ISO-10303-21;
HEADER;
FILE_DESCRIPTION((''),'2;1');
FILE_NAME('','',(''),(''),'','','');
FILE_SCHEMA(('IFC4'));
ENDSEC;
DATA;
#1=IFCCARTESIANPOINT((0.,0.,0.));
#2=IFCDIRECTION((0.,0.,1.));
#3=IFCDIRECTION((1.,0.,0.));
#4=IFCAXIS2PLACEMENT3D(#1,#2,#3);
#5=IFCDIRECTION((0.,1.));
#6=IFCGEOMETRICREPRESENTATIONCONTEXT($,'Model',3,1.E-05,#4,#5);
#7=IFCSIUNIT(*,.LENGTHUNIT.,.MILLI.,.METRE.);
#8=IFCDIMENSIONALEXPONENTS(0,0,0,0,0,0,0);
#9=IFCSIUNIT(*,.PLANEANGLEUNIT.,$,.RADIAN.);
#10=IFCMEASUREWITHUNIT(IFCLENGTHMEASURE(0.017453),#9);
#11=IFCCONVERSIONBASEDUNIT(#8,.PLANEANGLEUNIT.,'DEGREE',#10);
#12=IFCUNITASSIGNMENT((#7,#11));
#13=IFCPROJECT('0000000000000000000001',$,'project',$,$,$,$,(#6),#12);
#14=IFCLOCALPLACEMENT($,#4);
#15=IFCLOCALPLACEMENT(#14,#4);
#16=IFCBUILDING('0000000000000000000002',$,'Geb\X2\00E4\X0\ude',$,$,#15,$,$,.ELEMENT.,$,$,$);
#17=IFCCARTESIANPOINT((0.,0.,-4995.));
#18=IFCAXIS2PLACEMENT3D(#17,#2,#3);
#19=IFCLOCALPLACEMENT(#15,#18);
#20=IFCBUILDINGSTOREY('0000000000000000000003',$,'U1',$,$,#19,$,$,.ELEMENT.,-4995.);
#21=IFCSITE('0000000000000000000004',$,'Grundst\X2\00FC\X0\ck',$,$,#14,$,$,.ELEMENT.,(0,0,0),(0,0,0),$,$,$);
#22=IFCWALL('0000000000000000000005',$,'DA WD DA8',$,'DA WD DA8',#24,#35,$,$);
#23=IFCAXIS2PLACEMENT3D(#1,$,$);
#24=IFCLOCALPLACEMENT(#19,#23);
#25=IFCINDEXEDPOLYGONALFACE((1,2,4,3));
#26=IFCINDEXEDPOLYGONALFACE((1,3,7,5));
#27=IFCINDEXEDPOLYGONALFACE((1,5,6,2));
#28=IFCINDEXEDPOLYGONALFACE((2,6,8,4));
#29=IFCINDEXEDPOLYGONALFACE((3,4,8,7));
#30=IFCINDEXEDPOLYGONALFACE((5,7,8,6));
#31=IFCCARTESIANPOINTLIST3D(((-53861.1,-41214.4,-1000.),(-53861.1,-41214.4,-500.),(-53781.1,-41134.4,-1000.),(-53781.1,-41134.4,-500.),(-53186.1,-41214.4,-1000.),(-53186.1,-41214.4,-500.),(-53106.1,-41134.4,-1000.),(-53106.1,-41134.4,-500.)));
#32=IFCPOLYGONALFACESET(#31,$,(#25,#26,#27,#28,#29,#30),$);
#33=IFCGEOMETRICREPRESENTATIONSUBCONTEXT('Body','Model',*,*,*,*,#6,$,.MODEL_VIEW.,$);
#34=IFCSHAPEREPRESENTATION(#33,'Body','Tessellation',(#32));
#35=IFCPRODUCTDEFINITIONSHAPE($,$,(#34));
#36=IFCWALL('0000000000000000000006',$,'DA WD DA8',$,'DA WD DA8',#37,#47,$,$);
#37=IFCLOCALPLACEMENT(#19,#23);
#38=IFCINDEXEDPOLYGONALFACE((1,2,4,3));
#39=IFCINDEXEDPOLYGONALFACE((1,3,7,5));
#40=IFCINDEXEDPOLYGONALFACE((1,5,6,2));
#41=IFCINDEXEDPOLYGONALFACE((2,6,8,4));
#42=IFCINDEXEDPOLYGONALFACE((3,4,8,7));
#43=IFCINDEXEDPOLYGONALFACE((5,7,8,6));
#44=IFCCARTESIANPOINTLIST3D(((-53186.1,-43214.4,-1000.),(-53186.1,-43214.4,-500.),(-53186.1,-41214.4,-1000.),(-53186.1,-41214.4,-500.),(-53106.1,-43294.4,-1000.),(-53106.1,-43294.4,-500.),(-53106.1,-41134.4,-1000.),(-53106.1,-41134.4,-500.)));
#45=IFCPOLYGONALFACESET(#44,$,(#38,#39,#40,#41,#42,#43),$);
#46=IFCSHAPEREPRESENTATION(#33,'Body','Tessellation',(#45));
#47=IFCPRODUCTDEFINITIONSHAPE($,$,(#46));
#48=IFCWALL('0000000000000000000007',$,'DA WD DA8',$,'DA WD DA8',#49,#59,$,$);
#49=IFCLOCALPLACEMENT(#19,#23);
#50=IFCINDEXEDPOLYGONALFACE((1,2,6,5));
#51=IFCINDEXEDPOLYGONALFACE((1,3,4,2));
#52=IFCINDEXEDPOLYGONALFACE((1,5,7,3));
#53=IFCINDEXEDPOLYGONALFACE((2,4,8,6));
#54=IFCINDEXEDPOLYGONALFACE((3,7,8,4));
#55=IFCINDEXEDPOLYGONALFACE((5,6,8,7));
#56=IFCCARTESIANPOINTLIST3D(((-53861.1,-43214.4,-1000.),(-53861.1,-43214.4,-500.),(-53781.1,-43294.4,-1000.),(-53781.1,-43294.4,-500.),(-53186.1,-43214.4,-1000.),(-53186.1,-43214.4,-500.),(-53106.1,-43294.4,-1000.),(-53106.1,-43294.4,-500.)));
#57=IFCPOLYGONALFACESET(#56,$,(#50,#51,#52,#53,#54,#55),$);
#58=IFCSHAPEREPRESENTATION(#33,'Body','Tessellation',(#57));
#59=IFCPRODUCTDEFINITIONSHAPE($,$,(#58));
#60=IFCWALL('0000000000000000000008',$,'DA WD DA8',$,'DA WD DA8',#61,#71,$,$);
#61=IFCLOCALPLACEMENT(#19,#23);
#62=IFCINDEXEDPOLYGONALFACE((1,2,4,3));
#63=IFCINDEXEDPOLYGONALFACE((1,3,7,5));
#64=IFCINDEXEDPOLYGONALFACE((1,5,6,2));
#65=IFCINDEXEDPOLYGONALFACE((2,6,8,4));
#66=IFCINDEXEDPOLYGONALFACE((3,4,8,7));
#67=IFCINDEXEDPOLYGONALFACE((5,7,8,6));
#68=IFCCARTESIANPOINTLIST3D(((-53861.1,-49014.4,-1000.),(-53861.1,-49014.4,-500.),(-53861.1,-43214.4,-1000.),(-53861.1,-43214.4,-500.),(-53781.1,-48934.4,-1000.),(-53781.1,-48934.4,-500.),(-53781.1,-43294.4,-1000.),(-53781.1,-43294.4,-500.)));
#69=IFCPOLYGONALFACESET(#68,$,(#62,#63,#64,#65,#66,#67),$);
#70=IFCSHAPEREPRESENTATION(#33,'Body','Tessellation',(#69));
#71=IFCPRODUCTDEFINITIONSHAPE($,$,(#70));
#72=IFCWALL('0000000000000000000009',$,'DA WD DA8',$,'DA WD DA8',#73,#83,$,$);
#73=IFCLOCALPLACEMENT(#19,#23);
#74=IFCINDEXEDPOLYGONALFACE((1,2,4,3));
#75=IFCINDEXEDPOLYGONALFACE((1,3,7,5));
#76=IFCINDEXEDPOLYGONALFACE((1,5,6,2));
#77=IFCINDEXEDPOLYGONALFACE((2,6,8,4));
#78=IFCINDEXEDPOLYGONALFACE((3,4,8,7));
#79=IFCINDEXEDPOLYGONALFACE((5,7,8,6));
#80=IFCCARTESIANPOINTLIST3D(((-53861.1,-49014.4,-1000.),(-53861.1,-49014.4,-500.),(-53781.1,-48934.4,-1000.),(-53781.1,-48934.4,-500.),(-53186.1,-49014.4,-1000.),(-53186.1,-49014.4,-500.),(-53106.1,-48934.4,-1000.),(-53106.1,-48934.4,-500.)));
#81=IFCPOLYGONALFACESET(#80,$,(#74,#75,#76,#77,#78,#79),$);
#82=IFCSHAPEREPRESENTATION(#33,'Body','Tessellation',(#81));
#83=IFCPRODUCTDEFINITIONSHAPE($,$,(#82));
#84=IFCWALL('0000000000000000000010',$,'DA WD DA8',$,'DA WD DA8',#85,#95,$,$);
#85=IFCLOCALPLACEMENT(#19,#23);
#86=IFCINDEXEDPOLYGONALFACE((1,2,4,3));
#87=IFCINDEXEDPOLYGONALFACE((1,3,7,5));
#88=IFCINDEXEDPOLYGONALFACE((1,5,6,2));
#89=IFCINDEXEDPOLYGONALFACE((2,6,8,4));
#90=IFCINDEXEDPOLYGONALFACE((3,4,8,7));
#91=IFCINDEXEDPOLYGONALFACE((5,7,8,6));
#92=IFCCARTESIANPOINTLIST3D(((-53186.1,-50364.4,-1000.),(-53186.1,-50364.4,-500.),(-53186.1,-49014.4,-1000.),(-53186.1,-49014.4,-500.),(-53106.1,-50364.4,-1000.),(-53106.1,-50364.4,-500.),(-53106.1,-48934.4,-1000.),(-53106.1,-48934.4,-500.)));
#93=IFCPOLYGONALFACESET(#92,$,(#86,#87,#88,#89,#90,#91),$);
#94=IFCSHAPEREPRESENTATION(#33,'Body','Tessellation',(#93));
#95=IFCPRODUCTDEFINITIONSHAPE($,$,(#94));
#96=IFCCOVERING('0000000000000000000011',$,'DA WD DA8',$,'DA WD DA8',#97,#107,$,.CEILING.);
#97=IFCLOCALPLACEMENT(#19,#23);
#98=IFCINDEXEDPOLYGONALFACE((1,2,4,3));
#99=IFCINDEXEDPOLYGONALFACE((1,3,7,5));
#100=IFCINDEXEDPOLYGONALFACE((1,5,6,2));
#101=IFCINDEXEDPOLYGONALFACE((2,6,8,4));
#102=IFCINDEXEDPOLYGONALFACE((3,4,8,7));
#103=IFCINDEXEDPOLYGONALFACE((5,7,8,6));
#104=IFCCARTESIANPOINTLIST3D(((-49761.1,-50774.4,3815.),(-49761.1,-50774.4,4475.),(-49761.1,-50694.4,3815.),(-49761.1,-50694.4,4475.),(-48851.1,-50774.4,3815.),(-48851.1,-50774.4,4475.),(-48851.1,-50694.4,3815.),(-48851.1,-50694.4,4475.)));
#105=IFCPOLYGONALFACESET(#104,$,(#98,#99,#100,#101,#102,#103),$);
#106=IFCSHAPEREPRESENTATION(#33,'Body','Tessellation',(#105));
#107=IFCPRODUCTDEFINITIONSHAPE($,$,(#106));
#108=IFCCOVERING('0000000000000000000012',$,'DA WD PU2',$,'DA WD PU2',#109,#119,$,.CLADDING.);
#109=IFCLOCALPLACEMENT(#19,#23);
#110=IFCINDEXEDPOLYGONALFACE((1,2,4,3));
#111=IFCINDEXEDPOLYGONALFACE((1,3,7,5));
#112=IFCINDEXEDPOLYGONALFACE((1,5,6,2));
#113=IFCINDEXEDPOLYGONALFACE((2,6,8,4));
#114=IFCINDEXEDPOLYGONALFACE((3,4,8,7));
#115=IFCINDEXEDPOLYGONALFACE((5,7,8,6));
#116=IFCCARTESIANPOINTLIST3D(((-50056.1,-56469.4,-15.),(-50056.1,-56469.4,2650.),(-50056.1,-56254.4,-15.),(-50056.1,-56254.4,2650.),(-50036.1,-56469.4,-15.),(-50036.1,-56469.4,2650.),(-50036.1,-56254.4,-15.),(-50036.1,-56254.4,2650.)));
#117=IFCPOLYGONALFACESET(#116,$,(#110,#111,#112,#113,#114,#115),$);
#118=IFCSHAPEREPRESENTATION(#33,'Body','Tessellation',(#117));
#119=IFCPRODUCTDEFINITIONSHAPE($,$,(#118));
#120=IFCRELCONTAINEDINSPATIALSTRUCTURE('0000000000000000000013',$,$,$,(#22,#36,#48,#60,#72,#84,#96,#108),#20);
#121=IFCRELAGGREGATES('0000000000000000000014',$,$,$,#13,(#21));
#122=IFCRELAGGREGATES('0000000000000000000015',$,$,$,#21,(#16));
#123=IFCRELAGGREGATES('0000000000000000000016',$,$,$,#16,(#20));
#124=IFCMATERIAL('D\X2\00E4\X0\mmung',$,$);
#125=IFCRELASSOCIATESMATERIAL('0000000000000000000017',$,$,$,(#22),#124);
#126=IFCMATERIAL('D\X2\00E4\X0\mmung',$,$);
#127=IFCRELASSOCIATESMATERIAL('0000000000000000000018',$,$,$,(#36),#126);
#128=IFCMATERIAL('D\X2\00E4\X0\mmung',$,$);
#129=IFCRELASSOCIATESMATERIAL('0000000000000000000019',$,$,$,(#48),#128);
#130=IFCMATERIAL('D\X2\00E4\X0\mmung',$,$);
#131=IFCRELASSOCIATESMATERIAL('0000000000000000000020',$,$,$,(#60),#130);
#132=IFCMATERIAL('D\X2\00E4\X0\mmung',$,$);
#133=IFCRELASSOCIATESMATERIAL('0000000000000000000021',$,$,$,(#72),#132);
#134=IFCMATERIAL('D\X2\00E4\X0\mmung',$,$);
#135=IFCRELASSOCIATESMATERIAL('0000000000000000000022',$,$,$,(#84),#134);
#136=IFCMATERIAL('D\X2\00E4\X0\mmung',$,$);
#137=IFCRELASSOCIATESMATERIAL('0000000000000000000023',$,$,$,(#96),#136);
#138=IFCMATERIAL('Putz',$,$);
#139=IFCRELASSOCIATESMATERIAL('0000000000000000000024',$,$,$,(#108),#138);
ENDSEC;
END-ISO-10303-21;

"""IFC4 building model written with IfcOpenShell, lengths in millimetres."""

from ifc_helpers import new_model, entity, si_unit, converted_unit, direction, frame, origin_with_axes, place, context, subcontext, project, spatial, line, indexed_curve, outline, extrude, material, element, save


model = new_model("IFC4")

# Units and contexts
model_context = context("Model", 3, precision=1e-05, world=origin_with_axes(), true_north=direction((0.0, 1.0)))
body_context = subcontext(model_context, "Body", "Model", "MODEL_VIEW")
ifc_project = project(units=[si_unit("LENGTHUNIT", "METRE", prefix="MILLI"), converted_unit("PLANEANGLEUNIT", "DEGREE", entity("IfcLengthMeasure", 0.017453), si_unit("PLANEANGLEUNIT", "RADIAN"), dimensions=[0, 0, 0, 0, 0, 0, 0])], contexts=[model_context])

# Site, building, storey
site_placement = place(None, origin_with_axes())
site = spatial("IfcSite", under=ifc_project, at=site_placement, Name="Grundstück", CompositionType="ELEMENT", RefLatitude=(0, 0, 0), RefLongitude=(0, 0, 0))
building_placement = place(site_placement, origin_with_axes())
building = spatial("IfcBuilding", under=site, at=building_placement, Name="Gebäude", CompositionType="ELEMENT")
storey_placement = place(building_placement, frame((0.0, 0.0, -4995.0), z_axis=(0.0, 0.0, 1.0), x_axis=(1.0, 0.0, 0.0)))
storey = spatial("IfcBuildingStorey", under=building, at=storey_placement, Name="U1", CompositionType="ELEMENT", Elevation=-4995.0)

# Walls
ifc_material_1 = material(Name="Dämmung")
wall_1_placement = place(storey_placement, frame((-53821.1, -41174.4, -1000.0), z_axis=(0.0, 0.0, 1.0), x_axis=(1.0, 0.0, 0.0)))
element("IfcWall", 1, at=wall_1_placement, inside=storey, material=ifc_material_1, Name="DA WD DA8", ObjectType="DA WD DA8", context=body_context, shape_type="SweptSolid", body=[
    extrude(outline(indexed_curve([(-40.0, -40.0), (40.0, 40.0), (715.0, 40.0), (635.0, -40.0)], segments=[line(1, 2), line(2, 3), line(3, 4), line(4, 1)])), origin_with_axes(), (0.0, 0.0, 1.0), 500.0),
])
ifc_material_2 = material(Name="Dämmung")
wall_2_placement = place(storey_placement, frame((-53146.1, -41174.4, -1000.0), z_axis=(0.0, 0.0, 1.0), x_axis=(0.0, -1.0, 0.0)))
element("IfcWall", 2, at=wall_2_placement, inside=storey, material=ifc_material_2, Name="DA WD DA8", ObjectType="DA WD DA8", context=body_context, shape_type="SweptSolid", body=[
    extrude(outline(indexed_curve([(40.0, -40.0), (-40.0, 40.0), (2120.0, 40.0), (2040.0, -40.0)], segments=[line(1, 2), line(2, 3), line(3, 4), line(4, 1)])), origin_with_axes(), (0.0, 0.0, 1.0), 500.0),
])
ifc_material_3 = material(Name="Dämmung")
wall_3_placement = place(storey_placement, frame((-53146.1, -43254.4, -1000.0), z_axis=(0.0, 0.0, 1.0), x_axis=(-1.0, 0.0, 0.0)))
element("IfcWall", 3, at=wall_3_placement, inside=storey, material=ifc_material_3, Name="DA WD DA8", ObjectType="DA WD DA8", context=body_context, shape_type="SweptSolid", body=[
    extrude(outline(indexed_curve([(40.0, -40.0), (-40.0, 40.0), (635.0, 40.0), (715.0, -40.0)], segments=[line(1, 2), line(2, 3), line(3, 4), line(4, 1)])), origin_with_axes(), (0.0, 0.0, 1.0), 500.0),
])
ifc_material_4 = material(Name="Dämmung")
wall_4_placement = place(storey_placement, frame((-53821.1, -43254.4, -1000.0), z_axis=(0.0, 0.0, 1.0), x_axis=(0.0, -1.0, 0.0)))
element("IfcWall", 4, at=wall_4_placement, inside=storey, material=ifc_material_4, Name="DA WD DA8", ObjectType="DA WD DA8", context=body_context, shape_type="SweptSolid", body=[
    extrude(outline(indexed_curve([(40.0, 40.0), (-40.0, -40.0), (5760.0, -40.0), (5680.0, 40.0)], segments=[line(1, 2), line(2, 3), line(3, 4), line(4, 1)])), origin_with_axes(), (0.0, 0.0, 1.0), 500.0),
])
ifc_material_5 = material(Name="Dämmung")
wall_5_placement = place(storey_placement, frame((-53821.1, -48974.4, -1000.0), z_axis=(0.0, 0.0, 1.0), x_axis=(1.0, 0.0, 0.0)))
element("IfcWall", 5, at=wall_5_placement, inside=storey, material=ifc_material_5, Name="DA WD DA8", ObjectType="DA WD DA8", context=body_context, shape_type="SweptSolid", body=[
    extrude(outline(indexed_curve([(-40.0, -40.0), (40.0, 40.0), (715.0, 40.0), (635.0, -40.0)], segments=[line(1, 2), line(2, 3), line(3, 4), line(4, 1)])), origin_with_axes(), (0.0, 0.0, 1.0), 500.0),
])
ifc_material_6 = material(Name="Dämmung")
wall_6_placement = place(storey_placement, frame((-53146.1, -48974.4, -1000.0), z_axis=(0.0, 0.0, 1.0), x_axis=(0.0, -1.0, 0.0)))
element("IfcWall", 6, at=wall_6_placement, inside=storey, material=ifc_material_6, Name="DA WD DA8", ObjectType="DA WD DA8", context=body_context, shape_type="SweptSolid", body=[
    extrude(outline(indexed_curve([(40.0, -40.0), (-40.0, 40.0), (1390.0, 40.0), (1390.0, -40.0)], segments=[line(1, 2), line(2, 3), line(3, 4), line(4, 1)])), origin_with_axes(), (0.0, 0.0, 1.0), 500.0),
])

# Coverings
ifc_material_7 = material(Name="Dämmung")
covering_1_placement = place(storey_placement, frame((-49761.1, -50734.4, 3815.0), z_axis=(0.0, 0.0, 1.0), x_axis=(1.0, 0.0, 0.0)))
element("IfcCovering", 7, at=covering_1_placement, inside=storey, material=ifc_material_7, Name="DA WD DA8", ObjectType="DA WD DA8", PredefinedType="CEILING", context=body_context, shape_type="SweptSolid", body=[
    extrude(outline(indexed_curve([(0.0, -40.0), (0.0, 40.0), (910.0, 40.0), (910.0, -40.0)], segments=[line(1, 2), line(2, 3), line(3, 4), line(4, 1)])), origin_with_axes(), (0.0, 0.0, 1.0), 660.0),
])
ifc_material_8 = material(Name="Putz")
covering_2_placement = place(storey_placement, frame((-50046.1, -56469.4, -15.0), z_axis=(0.0, 0.0, 1.0), x_axis=(0.0, 1.0, 0.0)))
element("IfcCovering", 8, at=covering_2_placement, inside=storey, material=ifc_material_8, Name="DA WD PU2", ObjectType="DA WD PU2", PredefinedType="CLADDING", context=body_context, shape_type="SweptSolid", body=[
    extrude(outline(indexed_curve([(0.0, -10.0), (0.0, 10.0), (215.0, 10.0), (215.0, -10.0)], segments=[line(1, 2), line(2, 3), line(3, 4), line(4, 1)])), origin_with_axes(), (0.0, 0.0, 1.0), 2665.0),
])

save(model, "model.ifc")
